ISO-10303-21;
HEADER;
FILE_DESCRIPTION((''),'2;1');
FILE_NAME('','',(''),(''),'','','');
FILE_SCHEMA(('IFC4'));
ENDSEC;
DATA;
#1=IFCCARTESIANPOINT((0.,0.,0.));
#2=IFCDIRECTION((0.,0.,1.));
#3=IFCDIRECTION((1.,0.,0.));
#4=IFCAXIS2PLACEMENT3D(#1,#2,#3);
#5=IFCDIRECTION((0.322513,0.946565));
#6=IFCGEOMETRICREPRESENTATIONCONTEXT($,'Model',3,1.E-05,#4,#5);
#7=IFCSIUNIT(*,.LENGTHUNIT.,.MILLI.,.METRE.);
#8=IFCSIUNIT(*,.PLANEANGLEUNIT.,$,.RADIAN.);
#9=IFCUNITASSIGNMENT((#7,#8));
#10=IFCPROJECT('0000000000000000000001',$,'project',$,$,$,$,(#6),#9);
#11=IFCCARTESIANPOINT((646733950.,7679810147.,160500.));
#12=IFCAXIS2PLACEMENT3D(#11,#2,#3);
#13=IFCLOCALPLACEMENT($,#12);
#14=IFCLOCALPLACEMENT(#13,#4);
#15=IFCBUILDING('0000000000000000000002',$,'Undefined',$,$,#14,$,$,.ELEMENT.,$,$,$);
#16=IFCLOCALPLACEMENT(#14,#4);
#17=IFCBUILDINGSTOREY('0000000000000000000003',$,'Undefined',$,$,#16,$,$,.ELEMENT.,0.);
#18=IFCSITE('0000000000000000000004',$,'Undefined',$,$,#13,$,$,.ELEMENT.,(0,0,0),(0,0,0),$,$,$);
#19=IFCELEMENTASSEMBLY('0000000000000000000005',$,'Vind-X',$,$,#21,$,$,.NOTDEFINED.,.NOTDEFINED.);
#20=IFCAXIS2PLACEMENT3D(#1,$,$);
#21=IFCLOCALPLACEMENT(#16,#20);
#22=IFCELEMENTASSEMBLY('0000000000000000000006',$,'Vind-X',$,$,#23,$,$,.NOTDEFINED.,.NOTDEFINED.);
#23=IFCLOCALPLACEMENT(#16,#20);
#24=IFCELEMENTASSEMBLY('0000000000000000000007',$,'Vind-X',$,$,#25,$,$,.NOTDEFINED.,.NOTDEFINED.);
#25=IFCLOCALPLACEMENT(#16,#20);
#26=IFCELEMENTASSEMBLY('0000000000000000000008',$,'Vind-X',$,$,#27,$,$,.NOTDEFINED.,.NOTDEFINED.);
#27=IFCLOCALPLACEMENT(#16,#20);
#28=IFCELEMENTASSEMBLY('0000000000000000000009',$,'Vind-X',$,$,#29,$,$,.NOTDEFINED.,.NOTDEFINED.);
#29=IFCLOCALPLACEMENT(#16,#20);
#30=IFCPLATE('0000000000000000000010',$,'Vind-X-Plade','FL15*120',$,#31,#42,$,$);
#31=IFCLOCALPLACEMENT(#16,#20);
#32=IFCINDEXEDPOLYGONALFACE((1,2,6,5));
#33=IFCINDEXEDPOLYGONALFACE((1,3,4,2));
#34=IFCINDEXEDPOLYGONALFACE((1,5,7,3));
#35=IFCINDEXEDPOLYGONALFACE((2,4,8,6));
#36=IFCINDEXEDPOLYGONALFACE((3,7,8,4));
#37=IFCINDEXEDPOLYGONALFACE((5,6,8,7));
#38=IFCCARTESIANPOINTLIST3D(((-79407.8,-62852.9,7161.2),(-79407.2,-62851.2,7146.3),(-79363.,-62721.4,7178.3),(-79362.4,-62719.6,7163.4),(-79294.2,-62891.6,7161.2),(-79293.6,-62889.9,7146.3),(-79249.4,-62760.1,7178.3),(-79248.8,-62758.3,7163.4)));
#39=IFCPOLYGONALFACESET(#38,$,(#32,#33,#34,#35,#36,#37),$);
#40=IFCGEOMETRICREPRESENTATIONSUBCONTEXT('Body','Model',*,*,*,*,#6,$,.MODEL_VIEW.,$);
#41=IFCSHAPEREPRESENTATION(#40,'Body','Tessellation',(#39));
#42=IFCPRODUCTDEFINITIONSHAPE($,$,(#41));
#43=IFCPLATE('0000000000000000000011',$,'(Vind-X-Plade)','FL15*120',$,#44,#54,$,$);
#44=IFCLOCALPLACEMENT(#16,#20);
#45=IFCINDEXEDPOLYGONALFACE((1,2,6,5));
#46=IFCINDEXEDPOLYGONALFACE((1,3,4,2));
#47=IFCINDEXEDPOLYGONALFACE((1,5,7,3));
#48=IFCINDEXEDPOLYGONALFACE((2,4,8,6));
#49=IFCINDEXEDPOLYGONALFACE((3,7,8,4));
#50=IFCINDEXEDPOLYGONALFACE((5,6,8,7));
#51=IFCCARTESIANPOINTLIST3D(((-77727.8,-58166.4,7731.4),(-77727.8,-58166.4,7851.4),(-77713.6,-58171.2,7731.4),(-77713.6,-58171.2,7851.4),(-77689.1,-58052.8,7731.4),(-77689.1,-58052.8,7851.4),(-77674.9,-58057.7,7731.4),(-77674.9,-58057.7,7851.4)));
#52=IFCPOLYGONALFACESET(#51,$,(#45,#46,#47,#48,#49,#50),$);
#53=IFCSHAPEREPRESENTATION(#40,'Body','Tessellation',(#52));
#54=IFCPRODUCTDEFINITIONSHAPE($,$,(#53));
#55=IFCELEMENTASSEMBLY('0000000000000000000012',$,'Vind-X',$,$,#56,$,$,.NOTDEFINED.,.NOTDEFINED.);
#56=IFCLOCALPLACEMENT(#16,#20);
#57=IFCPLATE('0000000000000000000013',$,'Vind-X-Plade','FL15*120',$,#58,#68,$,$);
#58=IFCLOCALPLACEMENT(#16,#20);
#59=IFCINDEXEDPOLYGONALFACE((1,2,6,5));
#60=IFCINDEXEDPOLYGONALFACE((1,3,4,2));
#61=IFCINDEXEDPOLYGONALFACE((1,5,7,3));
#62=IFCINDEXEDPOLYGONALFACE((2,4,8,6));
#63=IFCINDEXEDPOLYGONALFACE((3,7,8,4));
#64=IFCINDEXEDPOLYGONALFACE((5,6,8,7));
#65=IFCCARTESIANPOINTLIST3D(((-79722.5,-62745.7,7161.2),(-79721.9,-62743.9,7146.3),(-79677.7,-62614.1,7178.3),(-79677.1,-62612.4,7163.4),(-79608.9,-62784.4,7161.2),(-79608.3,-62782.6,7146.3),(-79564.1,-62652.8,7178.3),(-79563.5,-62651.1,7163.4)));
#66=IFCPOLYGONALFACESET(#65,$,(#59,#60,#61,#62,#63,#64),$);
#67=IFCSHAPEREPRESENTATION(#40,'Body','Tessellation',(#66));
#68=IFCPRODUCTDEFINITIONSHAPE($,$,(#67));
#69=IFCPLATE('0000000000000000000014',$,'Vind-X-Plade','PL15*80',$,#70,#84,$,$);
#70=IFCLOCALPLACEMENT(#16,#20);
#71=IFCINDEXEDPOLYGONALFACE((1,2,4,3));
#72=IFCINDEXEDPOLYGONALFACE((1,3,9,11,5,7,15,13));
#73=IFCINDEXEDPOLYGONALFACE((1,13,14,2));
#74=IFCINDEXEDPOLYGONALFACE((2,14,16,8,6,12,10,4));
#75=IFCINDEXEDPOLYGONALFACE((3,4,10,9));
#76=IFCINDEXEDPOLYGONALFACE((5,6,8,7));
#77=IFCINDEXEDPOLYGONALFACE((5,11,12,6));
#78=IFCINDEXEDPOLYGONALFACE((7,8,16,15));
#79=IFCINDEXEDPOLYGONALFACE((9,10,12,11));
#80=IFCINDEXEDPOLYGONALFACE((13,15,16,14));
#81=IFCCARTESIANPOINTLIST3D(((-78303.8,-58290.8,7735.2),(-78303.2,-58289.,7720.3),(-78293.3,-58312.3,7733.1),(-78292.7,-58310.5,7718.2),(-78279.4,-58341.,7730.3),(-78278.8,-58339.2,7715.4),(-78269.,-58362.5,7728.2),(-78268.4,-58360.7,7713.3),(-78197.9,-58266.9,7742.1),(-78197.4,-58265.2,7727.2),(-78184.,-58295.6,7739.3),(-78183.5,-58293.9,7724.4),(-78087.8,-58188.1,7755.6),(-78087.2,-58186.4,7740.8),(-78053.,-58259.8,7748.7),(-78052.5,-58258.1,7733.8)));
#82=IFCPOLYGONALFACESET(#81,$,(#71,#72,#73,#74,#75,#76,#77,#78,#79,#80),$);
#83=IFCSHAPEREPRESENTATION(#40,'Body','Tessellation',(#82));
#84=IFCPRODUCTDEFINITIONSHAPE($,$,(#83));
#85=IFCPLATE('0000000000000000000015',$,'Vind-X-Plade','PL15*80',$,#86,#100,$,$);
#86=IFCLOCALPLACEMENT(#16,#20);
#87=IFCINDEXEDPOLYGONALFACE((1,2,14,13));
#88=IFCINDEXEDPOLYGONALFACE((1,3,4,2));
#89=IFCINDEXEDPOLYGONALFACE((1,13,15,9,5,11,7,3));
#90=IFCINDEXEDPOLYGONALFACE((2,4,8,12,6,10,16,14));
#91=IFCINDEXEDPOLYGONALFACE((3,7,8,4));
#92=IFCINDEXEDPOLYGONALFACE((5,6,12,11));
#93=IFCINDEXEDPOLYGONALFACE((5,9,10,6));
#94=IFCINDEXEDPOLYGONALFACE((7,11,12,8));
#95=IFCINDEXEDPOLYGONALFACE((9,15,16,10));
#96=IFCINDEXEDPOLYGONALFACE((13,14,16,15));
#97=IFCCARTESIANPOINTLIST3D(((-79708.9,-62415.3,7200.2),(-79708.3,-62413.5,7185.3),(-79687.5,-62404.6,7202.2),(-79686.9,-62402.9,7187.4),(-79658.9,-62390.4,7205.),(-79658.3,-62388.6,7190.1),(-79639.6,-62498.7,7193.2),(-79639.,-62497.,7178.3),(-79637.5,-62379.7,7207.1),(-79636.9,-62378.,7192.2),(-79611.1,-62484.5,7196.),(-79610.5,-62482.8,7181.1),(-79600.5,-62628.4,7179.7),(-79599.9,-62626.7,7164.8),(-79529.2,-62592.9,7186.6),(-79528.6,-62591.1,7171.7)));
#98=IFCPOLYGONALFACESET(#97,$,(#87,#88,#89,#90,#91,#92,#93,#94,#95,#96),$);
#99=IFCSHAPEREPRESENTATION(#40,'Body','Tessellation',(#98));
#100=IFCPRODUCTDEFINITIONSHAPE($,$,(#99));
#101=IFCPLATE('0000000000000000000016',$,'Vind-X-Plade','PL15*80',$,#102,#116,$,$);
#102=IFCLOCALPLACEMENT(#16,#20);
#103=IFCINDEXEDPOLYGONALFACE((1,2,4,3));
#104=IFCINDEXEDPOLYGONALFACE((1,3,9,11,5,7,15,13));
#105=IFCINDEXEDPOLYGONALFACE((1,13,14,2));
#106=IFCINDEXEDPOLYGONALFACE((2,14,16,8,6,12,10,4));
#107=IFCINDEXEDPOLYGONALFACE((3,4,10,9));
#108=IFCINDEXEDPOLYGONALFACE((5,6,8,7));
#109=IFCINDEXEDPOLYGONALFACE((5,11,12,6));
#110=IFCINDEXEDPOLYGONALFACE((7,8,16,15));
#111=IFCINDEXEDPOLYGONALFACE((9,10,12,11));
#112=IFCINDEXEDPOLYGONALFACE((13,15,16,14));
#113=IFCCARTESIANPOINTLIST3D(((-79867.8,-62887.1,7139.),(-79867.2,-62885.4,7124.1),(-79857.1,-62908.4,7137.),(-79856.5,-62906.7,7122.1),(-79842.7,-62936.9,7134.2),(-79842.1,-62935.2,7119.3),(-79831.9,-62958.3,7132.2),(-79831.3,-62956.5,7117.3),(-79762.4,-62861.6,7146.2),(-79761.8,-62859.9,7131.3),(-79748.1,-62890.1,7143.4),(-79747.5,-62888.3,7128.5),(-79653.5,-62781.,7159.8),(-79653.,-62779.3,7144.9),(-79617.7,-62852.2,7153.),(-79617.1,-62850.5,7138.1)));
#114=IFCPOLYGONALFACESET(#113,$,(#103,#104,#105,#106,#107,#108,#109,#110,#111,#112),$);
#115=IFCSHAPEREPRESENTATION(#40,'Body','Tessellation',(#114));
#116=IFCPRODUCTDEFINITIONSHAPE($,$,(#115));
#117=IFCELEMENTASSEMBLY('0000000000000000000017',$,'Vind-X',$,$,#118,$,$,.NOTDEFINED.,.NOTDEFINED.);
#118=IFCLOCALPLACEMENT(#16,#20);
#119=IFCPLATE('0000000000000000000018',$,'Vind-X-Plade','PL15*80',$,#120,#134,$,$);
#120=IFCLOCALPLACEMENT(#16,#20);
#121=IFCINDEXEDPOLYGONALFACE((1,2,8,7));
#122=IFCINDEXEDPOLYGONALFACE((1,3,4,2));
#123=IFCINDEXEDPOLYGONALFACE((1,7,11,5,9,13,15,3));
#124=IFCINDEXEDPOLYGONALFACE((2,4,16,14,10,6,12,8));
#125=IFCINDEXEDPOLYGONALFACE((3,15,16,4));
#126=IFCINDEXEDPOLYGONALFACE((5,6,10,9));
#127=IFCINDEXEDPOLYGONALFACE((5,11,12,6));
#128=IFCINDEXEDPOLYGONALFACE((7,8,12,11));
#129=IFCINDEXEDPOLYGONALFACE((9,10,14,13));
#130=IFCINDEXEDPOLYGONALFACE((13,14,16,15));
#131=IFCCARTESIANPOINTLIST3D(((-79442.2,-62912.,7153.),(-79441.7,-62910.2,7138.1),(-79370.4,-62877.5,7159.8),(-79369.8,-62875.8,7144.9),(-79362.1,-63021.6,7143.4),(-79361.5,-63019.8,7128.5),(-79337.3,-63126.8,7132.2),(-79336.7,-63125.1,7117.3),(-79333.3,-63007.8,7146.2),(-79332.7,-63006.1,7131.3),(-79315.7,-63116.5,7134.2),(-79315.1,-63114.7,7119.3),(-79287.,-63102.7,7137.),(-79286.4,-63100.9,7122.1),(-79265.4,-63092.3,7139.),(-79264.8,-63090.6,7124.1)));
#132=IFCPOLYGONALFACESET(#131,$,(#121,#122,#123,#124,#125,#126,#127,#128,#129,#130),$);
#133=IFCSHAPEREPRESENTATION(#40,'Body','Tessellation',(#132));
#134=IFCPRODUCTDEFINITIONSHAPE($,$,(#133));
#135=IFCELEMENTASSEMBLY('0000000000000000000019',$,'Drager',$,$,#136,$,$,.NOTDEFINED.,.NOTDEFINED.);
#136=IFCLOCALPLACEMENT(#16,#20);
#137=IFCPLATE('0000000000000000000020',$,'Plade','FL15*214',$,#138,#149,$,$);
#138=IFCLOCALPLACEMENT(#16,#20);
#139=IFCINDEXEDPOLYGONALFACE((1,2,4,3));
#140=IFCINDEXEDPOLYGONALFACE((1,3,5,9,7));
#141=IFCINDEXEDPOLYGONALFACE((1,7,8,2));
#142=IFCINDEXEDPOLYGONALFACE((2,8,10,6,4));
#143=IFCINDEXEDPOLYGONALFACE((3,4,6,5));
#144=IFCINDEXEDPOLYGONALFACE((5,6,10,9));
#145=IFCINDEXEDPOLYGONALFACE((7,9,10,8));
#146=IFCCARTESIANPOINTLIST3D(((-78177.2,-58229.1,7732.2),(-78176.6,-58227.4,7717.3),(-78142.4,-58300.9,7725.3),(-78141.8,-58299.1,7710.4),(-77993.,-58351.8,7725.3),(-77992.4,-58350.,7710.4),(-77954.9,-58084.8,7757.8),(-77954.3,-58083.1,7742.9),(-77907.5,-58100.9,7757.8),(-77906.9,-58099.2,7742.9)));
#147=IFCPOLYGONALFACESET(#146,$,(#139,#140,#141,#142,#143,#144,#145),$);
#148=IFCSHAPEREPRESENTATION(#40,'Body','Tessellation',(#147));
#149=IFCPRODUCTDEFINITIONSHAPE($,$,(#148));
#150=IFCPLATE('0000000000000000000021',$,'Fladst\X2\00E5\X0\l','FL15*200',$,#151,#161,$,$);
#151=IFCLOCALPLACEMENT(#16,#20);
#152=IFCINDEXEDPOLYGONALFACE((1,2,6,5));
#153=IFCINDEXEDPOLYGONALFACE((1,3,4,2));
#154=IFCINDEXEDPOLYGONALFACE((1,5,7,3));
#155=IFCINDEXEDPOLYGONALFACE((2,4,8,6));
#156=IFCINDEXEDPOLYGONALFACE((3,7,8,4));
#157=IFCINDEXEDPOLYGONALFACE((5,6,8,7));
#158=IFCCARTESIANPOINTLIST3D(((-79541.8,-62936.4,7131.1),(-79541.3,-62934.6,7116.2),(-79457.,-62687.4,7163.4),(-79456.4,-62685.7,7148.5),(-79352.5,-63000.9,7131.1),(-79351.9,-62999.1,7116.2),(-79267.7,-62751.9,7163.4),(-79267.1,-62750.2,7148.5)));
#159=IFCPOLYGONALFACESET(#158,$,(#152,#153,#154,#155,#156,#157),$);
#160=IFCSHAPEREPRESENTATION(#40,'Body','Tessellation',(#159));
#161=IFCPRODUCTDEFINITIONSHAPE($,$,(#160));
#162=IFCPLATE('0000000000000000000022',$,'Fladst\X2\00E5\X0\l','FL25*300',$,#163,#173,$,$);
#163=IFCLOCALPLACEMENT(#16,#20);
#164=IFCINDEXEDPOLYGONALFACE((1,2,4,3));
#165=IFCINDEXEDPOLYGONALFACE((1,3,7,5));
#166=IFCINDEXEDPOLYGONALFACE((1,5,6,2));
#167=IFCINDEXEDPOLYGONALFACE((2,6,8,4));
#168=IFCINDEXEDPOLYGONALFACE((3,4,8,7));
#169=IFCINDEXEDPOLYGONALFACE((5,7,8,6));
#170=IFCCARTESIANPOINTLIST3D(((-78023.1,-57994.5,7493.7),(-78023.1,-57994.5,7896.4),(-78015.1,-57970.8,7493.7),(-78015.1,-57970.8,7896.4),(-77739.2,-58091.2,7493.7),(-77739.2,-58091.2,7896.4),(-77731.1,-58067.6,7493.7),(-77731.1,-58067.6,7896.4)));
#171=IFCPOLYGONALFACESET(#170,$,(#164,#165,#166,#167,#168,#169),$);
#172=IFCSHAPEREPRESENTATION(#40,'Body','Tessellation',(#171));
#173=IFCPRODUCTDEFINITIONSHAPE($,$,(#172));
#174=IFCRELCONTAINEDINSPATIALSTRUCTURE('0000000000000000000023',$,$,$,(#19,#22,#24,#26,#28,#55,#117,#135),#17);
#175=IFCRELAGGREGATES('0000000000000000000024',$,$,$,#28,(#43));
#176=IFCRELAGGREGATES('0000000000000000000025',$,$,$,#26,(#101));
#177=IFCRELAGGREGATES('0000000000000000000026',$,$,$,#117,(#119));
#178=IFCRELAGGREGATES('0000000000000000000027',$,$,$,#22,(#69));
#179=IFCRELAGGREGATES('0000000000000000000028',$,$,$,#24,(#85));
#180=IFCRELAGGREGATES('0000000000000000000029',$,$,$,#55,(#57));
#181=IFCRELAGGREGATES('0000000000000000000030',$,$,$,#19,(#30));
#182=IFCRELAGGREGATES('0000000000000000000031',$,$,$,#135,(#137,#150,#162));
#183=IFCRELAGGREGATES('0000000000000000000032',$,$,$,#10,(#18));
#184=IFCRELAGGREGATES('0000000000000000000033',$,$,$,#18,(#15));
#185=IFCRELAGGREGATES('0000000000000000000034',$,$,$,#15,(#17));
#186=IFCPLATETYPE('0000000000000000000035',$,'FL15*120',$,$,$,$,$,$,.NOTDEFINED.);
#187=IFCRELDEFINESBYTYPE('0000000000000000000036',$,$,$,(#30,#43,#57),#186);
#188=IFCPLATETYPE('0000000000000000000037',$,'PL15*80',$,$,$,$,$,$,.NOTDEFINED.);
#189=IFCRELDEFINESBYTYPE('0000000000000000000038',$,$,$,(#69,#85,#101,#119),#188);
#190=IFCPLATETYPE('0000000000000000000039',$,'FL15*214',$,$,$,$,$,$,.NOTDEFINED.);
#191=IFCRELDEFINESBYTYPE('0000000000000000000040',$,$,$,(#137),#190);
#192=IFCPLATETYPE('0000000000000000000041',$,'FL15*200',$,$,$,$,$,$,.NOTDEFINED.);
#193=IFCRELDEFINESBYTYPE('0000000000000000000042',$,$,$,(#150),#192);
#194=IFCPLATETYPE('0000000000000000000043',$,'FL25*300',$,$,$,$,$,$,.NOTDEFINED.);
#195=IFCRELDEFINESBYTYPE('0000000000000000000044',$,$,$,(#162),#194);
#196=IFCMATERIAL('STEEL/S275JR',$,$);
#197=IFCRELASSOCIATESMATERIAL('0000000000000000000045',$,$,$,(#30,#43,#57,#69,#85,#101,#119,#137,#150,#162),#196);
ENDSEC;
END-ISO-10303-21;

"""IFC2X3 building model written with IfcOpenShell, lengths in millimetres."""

from ifc_helpers import new_model, si_unit, direction, frame, origin_with_axes, place, context, subcontext, project, spatial, polyline, outline, extrude, boolean, material, type_object, element, aggregate, save


model = new_model("IFC2X3")

# Units and contexts
model_context = context("Model", 3, precision=1e-05, world=origin_with_axes(), true_north=direction((0.322513, 0.946565)))
body_context = subcontext(model_context, "Body", "Model", "MODEL_VIEW")
ifc_project = project(units=[si_unit("LENGTHUNIT", "METRE", prefix="MILLI"), si_unit("PLANEANGLEUNIT", "RADIAN")], contexts=[model_context])

# Site, building, storey
site_placement = place(None, frame((646733950.0, 7679810147.0, 160500.0), z_axis=(0.0, 0.0, 1.0), x_axis=(1.0, 0.0, 0.0)))
site = spatial("IfcSite", under=ifc_project, at=site_placement, Name="Undefined", CompositionType="ELEMENT", RefLatitude=(0, 0, 0), RefLongitude=(0, 0, 0))
building_placement = place(site_placement, origin_with_axes())
building = spatial("IfcBuilding", under=site, at=building_placement, Name="Undefined", CompositionType="ELEMENT")
storey_placement = place(building_placement, origin_with_axes())
storey = spatial("IfcBuildingStorey", under=building, at=storey_placement, Name="Undefined", CompositionType="ELEMENT", Elevation=0.0)

# Element assemblies
assembly_1_placement = place(storey_placement, origin_with_axes())
assembly_1 = element("IfcElementAssembly", 1, at=assembly_1_placement, inside=storey, Name="Vind-X", AssemblyPlace="NOTDEFINED", PredefinedType="NOTDEFINED")
assembly_2_placement = place(storey_placement, origin_with_axes())
assembly_2 = element("IfcElementAssembly", 2, at=assembly_2_placement, inside=storey, Name="Vind-X", AssemblyPlace="NOTDEFINED", PredefinedType="NOTDEFINED")
assembly_3_placement = place(storey_placement, origin_with_axes())
assembly_3 = element("IfcElementAssembly", 3, at=assembly_3_placement, inside=storey, Name="Vind-X", AssemblyPlace="NOTDEFINED", PredefinedType="NOTDEFINED")

# Element assembly
assembly_4_placement = place(storey_placement, origin_with_axes())
assembly_4 = element("IfcElementAssembly", 4, at=assembly_4_placement, inside=storey, Name="Vind-X", AssemblyPlace="NOTDEFINED", PredefinedType="NOTDEFINED")

# Element assembly
ifc_material_1 = material(Name="STEEL/S275JR")
assembly_5_placement = place(storey_placement, origin_with_axes())
assembly_5 = element("IfcElementAssembly", 5, at=assembly_5_placement, inside=storey, Name="Vind-X", AssemblyPlace="NOTDEFINED", PredefinedType="NOTDEFINED")

# Plates
plate_type_1 = type_object("IfcPlateType", Name="FL15*120", PredefinedType="NOTDEFINED")
plate_1_placement = place(assembly_1_placement, frame((-79385.1, -62786.3, 7162.3), z_axis=(0.039304, 0.115357, -0.992546), x_axis=(0.946565, -0.322513, 0.0)))
plate_1 = element("IfcPlate", 6, at=plate_1_placement, type_object=plate_type_1, material=ifc_material_1, Name="Vind-X-Plade", Description="FL15*120", context=body_context, shape_type="SweptSolid", body=[
    extrude(outline(polyline([(0.0, -70.0), (0.0, 70.0), (120.0, 70.0), (120.0, -70.0), (0.0, -70.0)])), frame((0.0, 0.0, -7.5), z_axis=(0.0, 0.0, 1.0), x_axis=(1.0, 0.0, 0.0)), (0.0, 0.0, 1.0), 15.0),
])
plate_2_placement = place(assembly_5_placement, frame((-77720.7, -58168.8, 7851.4), z_axis=(-0.946565, 0.322513, 0.0), x_axis=(0.322513, 0.946565, 0.0)))
plate_2 = element("IfcPlate", 7, at=plate_2_placement, type_object=plate_type_1, material=ifc_material_1, Name="(Vind-X-Plade)", Description="FL15*120", context=body_context, shape_type="SweptSolid", body=[
    extrude(outline(polyline([(0.0, 0.0), (120.0, 0.0), (120.0, 120.0), (0.0, 120.0), (0.0, 0.0)])), frame((0.0, 0.0, -7.5), z_axis=(0.0, 0.0, 1.0), x_axis=(1.0, 0.0, 0.0)), (0.0, 0.0, 1.0), 15.0),
])
aggregate(assembly_5, [plate_2])

# Element assembly, plate
assembly_6_placement = place(storey_placement, origin_with_axes())
assembly_6 = element("IfcElementAssembly", 8, at=assembly_6_placement, inside=storey, Name="Vind-X", AssemblyPlace="NOTDEFINED", PredefinedType="NOTDEFINED")
plate_3_placement = place(assembly_6_placement, frame((-79586.2, -62717.7, 7162.3), z_axis=(0.039304, 0.115357, -0.992546), x_axis=(-0.946565, 0.322513, 0.0)))
plate_3 = element("IfcPlate", 9, at=plate_3_placement, type_object=plate_type_1, material=ifc_material_1, Name="Vind-X-Plade", Description="FL15*120", context=body_context, shape_type="SweptSolid", body=[
    extrude(outline(polyline([(0.0, -70.0), (0.0, 70.0), (120.0, 70.0), (120.0, -70.0), (0.0, -70.0)])), frame((0.0, 0.0, -7.5), z_axis=(0.0, 0.0, 1.0), x_axis=(1.0, 0.0, 0.0)), (0.0, 0.0, 1.0), 15.0),
])

# Plates
plate_type_2 = type_object("IfcPlateType", Name="PL15*80", PredefinedType="NOTDEFINED")
plate_4_placement = place(assembly_2_placement, frame((-78268.7, -58361.6, 7720.8), z_axis=(-0.039304, -0.115357, 0.992546), x_axis=(0.899843, 0.427783, 0.085352)))
plate_4 = element("IfcPlate", 10, at=plate_4_placement, type_object=plate_type_2, material=ifc_material_1, Name="Vind-X-Plade", Description="PL15*80", context=body_context, shape_type="SweptSolid", body=[
    extrude(outline(polyline([(0.0, 0.0), (240.0, 0.0), (240.0, 80.0), (0.0, 80.0), (0.0, 56.0), (106.0, 56.0), (106.0, 24.0), (0.0, 24.0), (0.0, 0.0)])), frame((0.0, 0.0, -7.5), z_axis=(0.0, 0.0, 1.0), x_axis=(1.0, 0.0, 0.0)), (0.0, 0.0, 1.0), 15.0),
])
plate_5_placement = place(assembly_3_placement, frame((-79600.2, -62627.6, 7172.2), z_axis=(-0.039304, -0.115357, 0.992546), x_axis=(0.891424, 0.444742, 0.08699)))
plate_5 = element("IfcPlate", 11, at=plate_5_placement, type_object=plate_type_2, material=ifc_material_1, Name="Vind-X-Plade", Description="PL15*80", context=body_context, shape_type="CSG", body=[
    boolean("DIFFERENCE", extrude(outline(polyline([(0.0, 0.0), (80.0, 0.0), (80.0, 240.0), (0.0, 240.0), (0.0, 0.0)])), frame((0.0, 0.0, -7.5), z_axis=(0.0, 0.0, 1.0), x_axis=(1.0, 0.0, 0.0)), (0.0, 0.0, 1.0), 15.0), extrude(outline(polyline([(0.0, 0.0), (106.0, 0.0), (106.0, 32.0), (0.0, 32.0), (0.0, 0.0)])), frame((56.0, 240.0, 8.5), z_axis=(0.0, 0.0, -1.0), x_axis=(0.0, -1.0, 0.0)), (0.0, 0.0, 1.0), 17.0)),
])
plate_6_placement = place(assembly_4_placement, frame((-79617.4, -62851.3, 7145.5), z_axis=(-0.039304, -0.115357, 0.992546), x_axis=(-0.448662, 0.88959, 0.085625)))
plate_6 = element("IfcPlate", 12, at=plate_6_placement, type_object=plate_type_2, material=ifc_material_1, Name="Vind-X-Plade", Description="PL15*80", context=body_context, shape_type="CSG", body=[
    boolean("DIFFERENCE", extrude(outline(polyline([(0.0, 0.0), (80.0, 0.0), (80.0, 240.0), (0.0, 240.0), (0.0, 0.0)])), frame((0.0, 0.0, -7.5), z_axis=(0.0, 0.0, 1.0), x_axis=(1.0, 0.0, 0.0)), (0.0, 0.0, 1.0), 15.0), extrude(outline(polyline([(0.0, 0.0), (106.0, 0.0), (106.0, 32.0), (0.0, 32.0), (0.0, 0.0)])), frame((56.0, 240.0, 8.5), z_axis=(0.0, 0.0, -1.0), x_axis=(0.0, -1.0, 0.0)), (0.0, 0.0, 1.0), 17.0)),
])
aggregate(assembly_4, [plate_6])

# Element assembly, plate
assembly_7_placement = place(storey_placement, origin_with_axes())
assembly_7 = element("IfcElementAssembly", 13, at=assembly_7_placement, inside=storey, Name="Vind-X", AssemblyPlace="NOTDEFINED", PredefinedType="NOTDEFINED")
plate_7_placement = place(assembly_7_placement, frame((-79442.0, -62911.1, 7145.5), z_axis=(0.039304, 0.115357, -0.992546), x_axis=(0.898474, 0.430595, 0.085625)))
plate_7 = element("IfcPlate", 14, at=plate_7_placement, type_object=plate_type_2, material=ifc_material_1, Name="Vind-X-Plade", Description="PL15*80", context=body_context, shape_type="CSG", body=[
    boolean("DIFFERENCE", extrude(outline(polyline([(0.0, 0.0), (80.0, 0.0), (80.0, 240.0), (0.0, 240.0), (0.0, 0.0)])), frame((0.0, 0.0, -7.5), z_axis=(0.0, 0.0, 1.0), x_axis=(1.0, 0.0, 0.0)), (0.0, 0.0, 1.0), 15.0), extrude(outline(polyline([(0.0, 0.0), (106.0, 0.0), (106.0, 32.0), (0.0, 32.0), (0.0, 0.0)])), frame((56.0, 240.0, 8.5), z_axis=(0.0, 0.0, -1.0), x_axis=(0.0, -1.0, 0.0)), (0.0, 0.0, 1.0), 17.0)),
])
aggregate(assembly_7, [plate_7])

# Element assembly, plates
assembly_8_placement = place(storey_placement, origin_with_axes())
assembly_8 = element("IfcElementAssembly", 15, at=assembly_8_placement, inside=storey, Name="Drager", AssemblyPlace="NOTDEFINED", PredefinedType="NOTDEFINED")
plate_type_3 = type_object("IfcPlateType", Name="FL15*214", PredefinedType="NOTDEFINED")
plate_8_placement = place(assembly_8_placement, frame((-77992.7, -58350.9, 7717.8), z_axis=(-0.039304, -0.115357, 0.992546), x_axis=(0.320109, 0.93951, 0.121869)))
plate_8 = element("IfcPlate", 16, at=plate_8_placement, type_object=plate_type_3, material=ifc_material_1, Name="Plade", Description="FL15*214", context=body_context, shape_type="SweptSolid", body=[
    extrude(outline(polyline([(0.0, 0.0), (267.0, 0.0), (267.0, 50.0), (57.1, 213.9), (0.0, 157.9), (0.0, 0.0)])), frame((0.0, 0.0, -7.5), z_axis=(0.0, 0.0, 1.0), x_axis=(1.0, 0.0, 0.0)), (0.0, 0.0, 1.0), 15.0),
])
plate_type_4 = type_object("IfcPlateType", Name="FL15*200", PredefinedType="NOTDEFINED")
plate_9_placement = place(assembly_8_placement, frame((-79456.7, -62686.5, 7155.9), z_axis=(-0.039304, -0.115357, 0.992546), x_axis=(-0.320109, -0.93951, -0.121869)))
plate_9 = element("IfcPlate", 17, at=plate_9_placement, type_object=plate_type_4, material=ifc_material_1, Name="Fladstål", Description="FL15*200", context=body_context, shape_type="SweptSolid", body=[
    extrude(outline(polyline([(0.0, 0.0), (265.0, 0.0), (265.0, 200.0), (0.0, 200.0), (0.0, 0.0)])), frame((0.0, 0.0, -7.5), z_axis=(0.0, 0.0, 1.0), x_axis=(1.0, 0.0, 0.0)), (0.0, 0.0, 1.0), 15.0),
])
plate_type_5 = type_object("IfcPlateType", Name="FL25*300", PredefinedType="NOTDEFINED")
plate_10_placement = place(assembly_8_placement, frame((-77877.1, -58031.0, 7493.7), z_axis=(-0.322513, -0.946565, 0.0), x_axis=(0.0, 0.0, 1.0)))
plate_10 = element("IfcPlate", 18, at=plate_10_placement, type_object=plate_type_5, material=ifc_material_1, Name="Fladstål", Description="FL25*300", context=body_context, shape_type="SweptSolid", body=[
    extrude(outline(polyline([(0.0, -150.0), (0.0, 150.0), (402.7, 150.0), (402.7, -150.0), (0.0, -150.0)])), frame((0.0, 0.0, -12.5), z_axis=(0.0, 0.0, 1.0), x_axis=(1.0, 0.0, 0.0)), (0.0, 0.0, 1.0), 25.0),
])

aggregate(assembly_2, [plate_4])
aggregate(assembly_3, [plate_5])

aggregate(assembly_6, [plate_3])
aggregate(assembly_1, [plate_1])
aggregate(assembly_8, [plate_8, plate_9, plate_10])

save(model, "model.ifc")
